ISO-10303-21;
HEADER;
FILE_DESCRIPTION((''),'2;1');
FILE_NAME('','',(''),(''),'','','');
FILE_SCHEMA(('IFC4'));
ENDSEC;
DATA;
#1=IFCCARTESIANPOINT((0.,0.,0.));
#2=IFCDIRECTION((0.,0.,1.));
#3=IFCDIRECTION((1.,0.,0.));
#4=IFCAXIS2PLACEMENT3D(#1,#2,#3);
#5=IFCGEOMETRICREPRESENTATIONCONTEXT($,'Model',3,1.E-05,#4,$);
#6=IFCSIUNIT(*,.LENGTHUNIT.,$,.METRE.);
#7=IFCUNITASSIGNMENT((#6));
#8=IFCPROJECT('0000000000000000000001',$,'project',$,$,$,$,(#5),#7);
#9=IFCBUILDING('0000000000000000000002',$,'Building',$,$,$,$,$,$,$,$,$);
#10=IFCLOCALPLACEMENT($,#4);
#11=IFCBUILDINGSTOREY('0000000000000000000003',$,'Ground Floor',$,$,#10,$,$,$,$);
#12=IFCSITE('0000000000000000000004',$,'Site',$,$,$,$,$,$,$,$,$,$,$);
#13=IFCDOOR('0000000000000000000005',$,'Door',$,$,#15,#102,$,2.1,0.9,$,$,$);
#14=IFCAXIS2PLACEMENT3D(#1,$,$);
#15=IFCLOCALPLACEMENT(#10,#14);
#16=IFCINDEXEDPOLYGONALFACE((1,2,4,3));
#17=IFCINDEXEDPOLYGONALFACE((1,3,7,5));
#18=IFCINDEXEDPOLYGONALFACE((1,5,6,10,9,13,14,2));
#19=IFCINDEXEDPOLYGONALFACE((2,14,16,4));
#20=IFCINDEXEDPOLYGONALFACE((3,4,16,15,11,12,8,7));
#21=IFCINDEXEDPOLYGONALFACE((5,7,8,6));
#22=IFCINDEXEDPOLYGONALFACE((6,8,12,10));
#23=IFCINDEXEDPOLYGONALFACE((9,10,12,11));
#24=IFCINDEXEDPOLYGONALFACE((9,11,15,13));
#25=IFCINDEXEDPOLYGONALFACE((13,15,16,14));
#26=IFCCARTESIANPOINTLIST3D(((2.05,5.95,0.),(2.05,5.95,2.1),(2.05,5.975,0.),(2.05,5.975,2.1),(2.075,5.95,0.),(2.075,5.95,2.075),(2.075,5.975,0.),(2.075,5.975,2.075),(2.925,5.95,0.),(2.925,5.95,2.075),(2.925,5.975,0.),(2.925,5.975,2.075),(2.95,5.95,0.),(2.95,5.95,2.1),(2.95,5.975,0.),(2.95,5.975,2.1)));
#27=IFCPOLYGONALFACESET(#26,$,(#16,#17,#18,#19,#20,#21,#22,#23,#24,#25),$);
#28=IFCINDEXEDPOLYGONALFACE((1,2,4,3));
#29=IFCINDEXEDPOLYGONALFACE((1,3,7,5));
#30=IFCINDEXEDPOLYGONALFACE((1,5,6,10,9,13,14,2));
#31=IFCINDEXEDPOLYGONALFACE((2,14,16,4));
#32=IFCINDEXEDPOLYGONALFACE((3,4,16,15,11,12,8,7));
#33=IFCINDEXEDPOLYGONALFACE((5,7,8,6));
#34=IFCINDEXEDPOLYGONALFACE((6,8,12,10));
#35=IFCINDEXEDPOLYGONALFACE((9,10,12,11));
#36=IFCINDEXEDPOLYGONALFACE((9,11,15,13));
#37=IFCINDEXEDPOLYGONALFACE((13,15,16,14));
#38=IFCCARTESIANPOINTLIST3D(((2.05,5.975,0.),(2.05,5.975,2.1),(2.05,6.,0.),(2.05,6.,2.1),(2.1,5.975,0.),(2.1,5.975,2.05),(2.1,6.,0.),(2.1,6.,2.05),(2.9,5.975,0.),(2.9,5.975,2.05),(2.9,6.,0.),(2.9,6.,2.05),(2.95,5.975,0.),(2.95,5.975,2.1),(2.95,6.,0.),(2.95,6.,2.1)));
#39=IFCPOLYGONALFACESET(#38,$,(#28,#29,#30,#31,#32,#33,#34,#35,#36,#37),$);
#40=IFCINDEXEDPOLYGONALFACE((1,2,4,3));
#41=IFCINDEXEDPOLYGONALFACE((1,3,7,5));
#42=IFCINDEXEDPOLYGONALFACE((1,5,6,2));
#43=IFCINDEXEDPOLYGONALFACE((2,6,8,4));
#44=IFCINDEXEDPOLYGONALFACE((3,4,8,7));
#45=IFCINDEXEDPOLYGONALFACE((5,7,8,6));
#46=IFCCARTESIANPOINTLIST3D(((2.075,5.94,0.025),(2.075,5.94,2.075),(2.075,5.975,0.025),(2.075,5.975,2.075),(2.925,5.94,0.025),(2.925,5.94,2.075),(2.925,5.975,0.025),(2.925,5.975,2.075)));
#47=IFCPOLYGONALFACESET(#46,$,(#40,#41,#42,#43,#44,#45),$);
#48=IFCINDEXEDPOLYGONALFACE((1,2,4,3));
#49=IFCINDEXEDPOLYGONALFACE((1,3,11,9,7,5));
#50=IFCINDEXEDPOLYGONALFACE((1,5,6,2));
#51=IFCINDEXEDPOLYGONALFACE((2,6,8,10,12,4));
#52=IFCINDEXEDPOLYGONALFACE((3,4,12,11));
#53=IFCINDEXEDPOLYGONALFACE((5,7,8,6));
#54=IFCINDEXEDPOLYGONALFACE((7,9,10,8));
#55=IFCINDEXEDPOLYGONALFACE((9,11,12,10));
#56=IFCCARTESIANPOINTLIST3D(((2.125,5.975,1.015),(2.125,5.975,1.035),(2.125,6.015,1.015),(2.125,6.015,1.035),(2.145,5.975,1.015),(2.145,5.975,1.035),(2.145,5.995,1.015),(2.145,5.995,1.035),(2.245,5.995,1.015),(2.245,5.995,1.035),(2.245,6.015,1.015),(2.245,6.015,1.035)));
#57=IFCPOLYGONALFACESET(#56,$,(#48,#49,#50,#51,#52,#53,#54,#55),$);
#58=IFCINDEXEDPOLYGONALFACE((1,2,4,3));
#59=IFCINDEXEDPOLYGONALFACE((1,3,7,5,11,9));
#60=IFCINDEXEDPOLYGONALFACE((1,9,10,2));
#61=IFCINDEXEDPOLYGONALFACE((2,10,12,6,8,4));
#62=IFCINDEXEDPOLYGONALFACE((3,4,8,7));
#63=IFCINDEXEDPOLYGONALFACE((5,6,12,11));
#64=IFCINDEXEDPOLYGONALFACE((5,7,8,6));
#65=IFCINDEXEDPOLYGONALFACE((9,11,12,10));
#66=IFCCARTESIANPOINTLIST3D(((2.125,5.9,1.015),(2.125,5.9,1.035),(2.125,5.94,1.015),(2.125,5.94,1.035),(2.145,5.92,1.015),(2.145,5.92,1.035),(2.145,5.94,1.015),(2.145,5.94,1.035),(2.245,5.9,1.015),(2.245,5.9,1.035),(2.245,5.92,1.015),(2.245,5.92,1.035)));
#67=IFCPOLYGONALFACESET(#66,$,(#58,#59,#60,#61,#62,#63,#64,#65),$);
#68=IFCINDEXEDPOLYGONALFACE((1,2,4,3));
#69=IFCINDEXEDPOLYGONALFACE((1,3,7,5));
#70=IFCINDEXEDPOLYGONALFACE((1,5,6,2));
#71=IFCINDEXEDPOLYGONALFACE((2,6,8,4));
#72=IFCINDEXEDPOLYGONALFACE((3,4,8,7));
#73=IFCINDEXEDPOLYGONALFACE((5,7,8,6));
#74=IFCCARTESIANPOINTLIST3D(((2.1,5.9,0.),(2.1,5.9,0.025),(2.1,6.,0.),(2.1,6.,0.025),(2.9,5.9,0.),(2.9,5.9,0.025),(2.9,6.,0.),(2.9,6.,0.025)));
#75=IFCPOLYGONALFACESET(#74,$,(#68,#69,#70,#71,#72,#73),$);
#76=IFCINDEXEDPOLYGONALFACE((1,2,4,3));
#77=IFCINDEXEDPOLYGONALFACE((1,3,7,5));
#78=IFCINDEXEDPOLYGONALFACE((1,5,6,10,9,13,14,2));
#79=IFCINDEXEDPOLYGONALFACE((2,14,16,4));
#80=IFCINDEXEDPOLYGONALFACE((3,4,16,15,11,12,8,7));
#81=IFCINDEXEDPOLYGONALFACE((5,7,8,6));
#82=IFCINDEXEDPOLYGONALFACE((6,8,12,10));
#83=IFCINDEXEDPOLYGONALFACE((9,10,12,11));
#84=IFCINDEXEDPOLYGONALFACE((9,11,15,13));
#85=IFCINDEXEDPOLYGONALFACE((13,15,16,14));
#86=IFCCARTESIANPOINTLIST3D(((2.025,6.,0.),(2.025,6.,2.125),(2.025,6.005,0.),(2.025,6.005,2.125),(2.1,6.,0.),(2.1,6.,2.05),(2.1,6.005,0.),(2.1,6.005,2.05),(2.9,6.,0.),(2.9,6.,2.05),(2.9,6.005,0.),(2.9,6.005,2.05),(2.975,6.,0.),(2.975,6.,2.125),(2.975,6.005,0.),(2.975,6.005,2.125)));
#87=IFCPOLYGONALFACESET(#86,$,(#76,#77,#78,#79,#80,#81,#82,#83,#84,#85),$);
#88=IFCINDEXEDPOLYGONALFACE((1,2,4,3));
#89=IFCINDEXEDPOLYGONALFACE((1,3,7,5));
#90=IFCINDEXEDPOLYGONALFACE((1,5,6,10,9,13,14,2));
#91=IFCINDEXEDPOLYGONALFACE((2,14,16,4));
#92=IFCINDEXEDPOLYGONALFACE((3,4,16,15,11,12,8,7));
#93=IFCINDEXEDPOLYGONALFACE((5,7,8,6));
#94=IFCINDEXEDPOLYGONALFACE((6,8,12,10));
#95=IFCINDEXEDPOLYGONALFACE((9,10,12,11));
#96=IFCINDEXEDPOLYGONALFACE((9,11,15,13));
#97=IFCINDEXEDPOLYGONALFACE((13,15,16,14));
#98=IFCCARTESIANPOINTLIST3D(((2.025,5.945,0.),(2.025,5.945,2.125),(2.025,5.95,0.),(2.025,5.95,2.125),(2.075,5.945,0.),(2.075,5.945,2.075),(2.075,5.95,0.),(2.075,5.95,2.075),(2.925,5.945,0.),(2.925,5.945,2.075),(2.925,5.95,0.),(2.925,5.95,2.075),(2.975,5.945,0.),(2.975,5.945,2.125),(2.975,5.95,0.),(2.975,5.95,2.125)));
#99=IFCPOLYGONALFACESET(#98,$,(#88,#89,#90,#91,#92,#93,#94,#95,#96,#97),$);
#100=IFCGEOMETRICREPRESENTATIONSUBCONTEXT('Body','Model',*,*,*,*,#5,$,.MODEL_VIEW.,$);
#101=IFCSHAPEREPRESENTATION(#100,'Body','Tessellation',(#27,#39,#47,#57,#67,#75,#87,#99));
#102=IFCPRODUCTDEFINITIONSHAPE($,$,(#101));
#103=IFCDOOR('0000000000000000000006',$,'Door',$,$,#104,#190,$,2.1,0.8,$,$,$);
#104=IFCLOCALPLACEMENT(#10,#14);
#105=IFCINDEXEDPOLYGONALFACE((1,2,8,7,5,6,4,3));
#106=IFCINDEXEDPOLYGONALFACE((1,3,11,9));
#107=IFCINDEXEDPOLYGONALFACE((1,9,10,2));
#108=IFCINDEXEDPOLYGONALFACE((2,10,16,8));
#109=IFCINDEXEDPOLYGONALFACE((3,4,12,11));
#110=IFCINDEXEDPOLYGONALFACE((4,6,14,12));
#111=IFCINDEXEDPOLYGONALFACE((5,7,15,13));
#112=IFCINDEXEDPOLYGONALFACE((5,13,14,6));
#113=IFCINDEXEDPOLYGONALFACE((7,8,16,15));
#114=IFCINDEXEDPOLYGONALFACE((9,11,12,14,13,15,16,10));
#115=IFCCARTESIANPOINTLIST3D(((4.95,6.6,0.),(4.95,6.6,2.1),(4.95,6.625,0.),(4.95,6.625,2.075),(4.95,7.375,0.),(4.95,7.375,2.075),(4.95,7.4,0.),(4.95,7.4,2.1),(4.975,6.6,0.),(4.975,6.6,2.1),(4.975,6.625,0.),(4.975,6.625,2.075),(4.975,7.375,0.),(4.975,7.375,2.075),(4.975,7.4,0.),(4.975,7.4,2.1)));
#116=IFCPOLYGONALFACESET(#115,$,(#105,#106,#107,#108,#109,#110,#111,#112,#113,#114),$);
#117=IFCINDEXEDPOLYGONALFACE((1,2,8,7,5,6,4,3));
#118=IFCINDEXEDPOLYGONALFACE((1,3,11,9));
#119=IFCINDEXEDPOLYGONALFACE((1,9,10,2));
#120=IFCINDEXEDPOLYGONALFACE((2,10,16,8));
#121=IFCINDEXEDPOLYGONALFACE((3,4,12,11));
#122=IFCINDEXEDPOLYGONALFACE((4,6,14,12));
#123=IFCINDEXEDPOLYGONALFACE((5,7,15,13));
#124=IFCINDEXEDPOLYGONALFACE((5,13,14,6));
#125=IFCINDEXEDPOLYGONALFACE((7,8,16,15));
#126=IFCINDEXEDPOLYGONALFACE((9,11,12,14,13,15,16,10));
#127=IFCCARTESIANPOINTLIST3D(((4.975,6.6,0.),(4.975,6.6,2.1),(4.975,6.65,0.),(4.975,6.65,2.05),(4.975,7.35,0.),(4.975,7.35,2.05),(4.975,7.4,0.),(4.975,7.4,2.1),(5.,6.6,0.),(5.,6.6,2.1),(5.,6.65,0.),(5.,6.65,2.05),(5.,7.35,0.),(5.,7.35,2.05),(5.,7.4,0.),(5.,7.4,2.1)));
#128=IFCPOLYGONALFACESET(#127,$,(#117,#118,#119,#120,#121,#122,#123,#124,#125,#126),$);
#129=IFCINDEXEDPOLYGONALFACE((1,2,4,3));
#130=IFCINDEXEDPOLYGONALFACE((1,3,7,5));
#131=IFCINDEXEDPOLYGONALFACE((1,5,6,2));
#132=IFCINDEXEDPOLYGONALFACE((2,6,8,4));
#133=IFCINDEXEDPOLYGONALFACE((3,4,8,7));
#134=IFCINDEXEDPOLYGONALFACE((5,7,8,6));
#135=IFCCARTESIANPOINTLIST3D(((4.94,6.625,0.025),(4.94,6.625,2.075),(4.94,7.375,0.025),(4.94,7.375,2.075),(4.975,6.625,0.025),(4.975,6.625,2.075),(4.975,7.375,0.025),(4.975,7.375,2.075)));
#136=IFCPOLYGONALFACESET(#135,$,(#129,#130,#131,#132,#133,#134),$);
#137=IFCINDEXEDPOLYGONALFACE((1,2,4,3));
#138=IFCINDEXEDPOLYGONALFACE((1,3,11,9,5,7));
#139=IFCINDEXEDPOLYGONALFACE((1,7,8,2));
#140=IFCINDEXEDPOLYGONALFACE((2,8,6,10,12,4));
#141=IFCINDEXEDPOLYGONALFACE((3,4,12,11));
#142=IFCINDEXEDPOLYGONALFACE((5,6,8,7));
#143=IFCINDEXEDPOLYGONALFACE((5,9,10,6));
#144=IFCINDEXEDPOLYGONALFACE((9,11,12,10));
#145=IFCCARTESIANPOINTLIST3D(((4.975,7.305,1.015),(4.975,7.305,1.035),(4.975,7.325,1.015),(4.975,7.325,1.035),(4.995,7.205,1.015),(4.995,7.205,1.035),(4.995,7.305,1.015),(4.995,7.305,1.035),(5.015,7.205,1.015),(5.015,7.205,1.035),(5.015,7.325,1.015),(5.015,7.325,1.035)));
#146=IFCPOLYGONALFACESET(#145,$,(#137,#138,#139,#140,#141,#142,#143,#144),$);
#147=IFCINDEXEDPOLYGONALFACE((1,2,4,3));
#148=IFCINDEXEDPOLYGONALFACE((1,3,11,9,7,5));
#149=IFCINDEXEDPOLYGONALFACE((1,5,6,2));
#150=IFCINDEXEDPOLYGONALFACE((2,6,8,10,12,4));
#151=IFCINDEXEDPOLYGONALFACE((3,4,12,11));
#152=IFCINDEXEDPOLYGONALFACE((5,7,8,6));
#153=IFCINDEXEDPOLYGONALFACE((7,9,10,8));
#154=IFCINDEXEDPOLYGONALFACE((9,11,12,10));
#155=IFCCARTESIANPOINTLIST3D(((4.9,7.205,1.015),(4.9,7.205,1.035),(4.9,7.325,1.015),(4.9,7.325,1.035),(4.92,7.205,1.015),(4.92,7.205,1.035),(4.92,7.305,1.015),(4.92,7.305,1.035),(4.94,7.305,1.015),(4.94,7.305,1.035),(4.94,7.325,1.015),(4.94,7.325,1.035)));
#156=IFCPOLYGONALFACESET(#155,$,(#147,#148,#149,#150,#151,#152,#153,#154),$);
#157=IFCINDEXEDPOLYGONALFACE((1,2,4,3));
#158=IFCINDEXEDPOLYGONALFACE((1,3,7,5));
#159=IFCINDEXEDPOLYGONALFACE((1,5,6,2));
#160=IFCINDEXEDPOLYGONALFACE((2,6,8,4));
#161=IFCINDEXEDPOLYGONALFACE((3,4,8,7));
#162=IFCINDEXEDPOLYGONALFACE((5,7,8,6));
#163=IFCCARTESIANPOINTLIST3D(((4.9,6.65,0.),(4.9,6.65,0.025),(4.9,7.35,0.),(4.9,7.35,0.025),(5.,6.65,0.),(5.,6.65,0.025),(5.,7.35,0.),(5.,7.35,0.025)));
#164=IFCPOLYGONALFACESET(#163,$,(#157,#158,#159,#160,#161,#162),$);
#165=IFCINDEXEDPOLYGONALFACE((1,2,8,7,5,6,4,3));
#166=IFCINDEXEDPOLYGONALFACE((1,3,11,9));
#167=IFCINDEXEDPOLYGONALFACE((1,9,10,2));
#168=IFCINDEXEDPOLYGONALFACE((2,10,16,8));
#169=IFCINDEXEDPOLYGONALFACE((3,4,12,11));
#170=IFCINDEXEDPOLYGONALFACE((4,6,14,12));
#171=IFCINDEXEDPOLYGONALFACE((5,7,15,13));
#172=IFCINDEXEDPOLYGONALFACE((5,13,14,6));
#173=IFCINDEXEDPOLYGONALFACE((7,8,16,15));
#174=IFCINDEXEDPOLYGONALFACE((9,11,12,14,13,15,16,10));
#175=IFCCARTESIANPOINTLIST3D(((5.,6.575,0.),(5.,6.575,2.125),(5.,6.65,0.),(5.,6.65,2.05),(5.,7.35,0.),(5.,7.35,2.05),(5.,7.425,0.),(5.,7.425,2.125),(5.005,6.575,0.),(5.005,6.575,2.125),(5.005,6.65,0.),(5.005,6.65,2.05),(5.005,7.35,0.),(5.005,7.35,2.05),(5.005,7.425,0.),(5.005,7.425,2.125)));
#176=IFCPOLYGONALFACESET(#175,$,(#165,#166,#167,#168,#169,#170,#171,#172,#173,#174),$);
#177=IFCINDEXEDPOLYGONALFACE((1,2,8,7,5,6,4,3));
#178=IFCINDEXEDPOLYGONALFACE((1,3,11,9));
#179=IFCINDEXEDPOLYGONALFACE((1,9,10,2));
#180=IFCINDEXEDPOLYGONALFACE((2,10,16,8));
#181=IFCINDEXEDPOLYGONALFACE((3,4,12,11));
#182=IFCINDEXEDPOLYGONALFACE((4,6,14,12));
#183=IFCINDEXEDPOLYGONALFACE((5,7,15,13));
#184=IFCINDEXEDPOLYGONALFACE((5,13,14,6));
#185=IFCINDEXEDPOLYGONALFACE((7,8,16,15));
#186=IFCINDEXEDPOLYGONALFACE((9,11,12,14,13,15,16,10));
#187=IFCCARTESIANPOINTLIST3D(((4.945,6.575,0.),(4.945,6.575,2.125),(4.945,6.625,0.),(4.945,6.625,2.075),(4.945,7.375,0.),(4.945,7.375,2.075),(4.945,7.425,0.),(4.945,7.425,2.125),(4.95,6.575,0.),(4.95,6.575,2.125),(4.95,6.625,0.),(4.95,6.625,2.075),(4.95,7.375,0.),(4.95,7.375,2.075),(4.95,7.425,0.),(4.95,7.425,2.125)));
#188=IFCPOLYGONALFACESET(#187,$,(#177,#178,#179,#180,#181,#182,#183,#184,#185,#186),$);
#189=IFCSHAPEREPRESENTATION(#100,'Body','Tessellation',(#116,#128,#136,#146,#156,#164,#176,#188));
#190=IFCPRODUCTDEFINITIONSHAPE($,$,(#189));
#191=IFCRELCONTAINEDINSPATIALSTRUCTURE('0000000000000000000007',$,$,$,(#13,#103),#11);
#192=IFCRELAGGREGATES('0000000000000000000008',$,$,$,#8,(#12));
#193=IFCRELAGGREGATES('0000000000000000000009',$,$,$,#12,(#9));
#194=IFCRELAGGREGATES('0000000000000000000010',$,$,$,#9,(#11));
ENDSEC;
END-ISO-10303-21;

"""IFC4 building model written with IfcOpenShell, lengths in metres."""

from ifc_helpers import new_model, si_unit, frame, origin_with_axes, place, context, subcontext, project, spatial, line, indexed_curve, outline, extrude, element, save


model = new_model("IFC4")

# Units and contexts
model_context = context("Model", 3, precision=1e-05, world=origin_with_axes())
body_context = subcontext(model_context, "Body", "Model", "MODEL_VIEW")
ifc_project = project(units=[si_unit("LENGTHUNIT", "METRE")], contexts=[model_context])

# Site, building, storey
site = spatial("IfcSite", under=ifc_project, Name="Site")
building = spatial("IfcBuilding", under=site, Name="Building")
storey_placement = place(None, origin_with_axes())
storey = spatial("IfcBuildingStorey", under=building, at=storey_placement, Name="Ground Floor")

# Doors
door_1_placement = place(storey_placement, frame((2.95, 6.0, 0.0), z_axis=(0.0, 0.0, 1.0), x_axis=(-1.0, 0.0, 0.0)))
element("IfcDoor", 1, at=door_1_placement, inside=storey, Name="Door", OverallHeight=2.1, OverallWidth=0.9, context=body_context, shape_type="SweptSolid", body=[
    extrude(outline(indexed_curve([(0.0, 0.0), (0.0, 2.1), (0.9, 2.1), (0.9, 0.0), (0.875, 0.0), (0.875, 2.075), (0.025, 2.075), (0.025, 0.0)], segments=[line(1, 2, 3, 4, 5, 6, 7, 8, 1)])), frame((0.0, 0.025, 0.0), z_axis=(0.0, -1.0, 0.0), x_axis=(1.0, 0.0, 0.0)), (0.0, 0.0, -1.0), 0.025),
    extrude(outline(indexed_curve([(0.0, 0.0), (0.0, 2.1), (0.9, 2.1), (0.9, 0.0), (0.85, 0.0), (0.85, 2.05), (0.05, 2.05), (0.05, 0.0)], segments=[line(1, 2, 3, 4, 5, 6, 7, 8, 1)])), frame((0.0, 0.0, 0.0), z_axis=(0.0, -1.0, 0.0), x_axis=(1.0, 0.0, 0.0)), (0.0, 0.0, -1.0), 0.025),
    extrude(outline(indexed_curve([(0.0, 0.0), (0.85, 0.0), (0.85, 0.035), (0.0, 0.035)], segments=[line(1, 2, 3, 4, 1)])), frame((0.025, 0.025, 0.025), z_axis=(0.0, 0.0, 1.0), x_axis=(1.0, 0.0, 0.0)), (0.0, 0.0, 1.0), 2.05),
    extrude(outline(indexed_curve([(0.0, 0.0), (0.0, -0.04), (-0.12, -0.04), (-0.12, -0.02), (-0.02, -0.02), (-0.02, 0.0)], segments=[line(1, 2, 3, 4, 5, 6, 1)])), frame((0.825, 0.025, 1.015), z_axis=(0.0, 0.0, 1.0), x_axis=(1.0, 0.0, 0.0)), (0.0, 0.0, 1.0), 0.02),
    extrude(outline(indexed_curve([(0.0, 0.0), (0.0, 0.04), (-0.12, 0.04), (-0.12, 0.02), (-0.02, 0.02), (-0.02, 0.0)], segments=[line(1, 2, 3, 4, 5, 6, 1)])), frame((0.825, 0.06, 1.015), z_axis=(0.0, 0.0, 1.0), x_axis=(1.0, 0.0, 0.0)), (0.0, 0.0, 1.0), 0.02),
    extrude(outline(indexed_curve([(0.0, 0.0), (0.8, 0.0), (0.8, 0.1), (0.0, 0.1)], segments=[line(1, 2, 3, 4, 1)])), frame((0.05, 0.0, 0.0), z_axis=(0.0, 0.0, 1.0), x_axis=(1.0, 0.0, 0.0)), (0.0, 0.0, 1.0), 0.025),
    extrude(outline(indexed_curve([(0.0, 0.0), (0.0, 2.125), (0.95, 2.125), (0.95, 0.0), (0.875, 0.0), (0.875, 2.05), (0.075, 2.05), (0.075, 0.0)], segments=[line(1, 2, 3, 4, 5, 6, 7, 8, 1)])), frame((-0.025, -0.005, 0.0), z_axis=(0.0, -1.0, 0.0), x_axis=(1.0, 0.0, 0.0)), (0.0, 0.0, -1.0), 0.005),
    extrude(outline(indexed_curve([(0.0, 0.0), (0.0, 2.125), (0.95, 2.125), (0.95, 0.0), (0.9, 0.0), (0.9, 2.075), (0.05, 2.075), (0.05, 0.0)], segments=[line(1, 2, 3, 4, 5, 6, 7, 8, 1)])), frame((-0.025, 0.05, 0.0), z_axis=(0.0, -1.0, 0.0), x_axis=(1.0, 0.0, 0.0)), (0.0, 0.0, -1.0), 0.005),
])
door_2_placement = place(storey_placement, frame((5.0, 6.6, 0.0), z_axis=(0.0, 0.0, 1.0), x_axis=(0.0, 1.0, 0.0)))
element("IfcDoor", 2, at=door_2_placement, inside=storey, Name="Door", OverallHeight=2.1, OverallWidth=0.8, context=body_context, shape_type="SweptSolid", body=[
    extrude(outline(indexed_curve([(0.0, 0.0), (0.0, 2.1), (0.8, 2.1), (0.8, 0.0), (0.775, 0.0), (0.775, 2.075), (0.025, 2.075), (0.025, 0.0)], segments=[line(1, 2, 3, 4, 5, 6, 7, 8, 1)])), frame((0.0, 0.025, 0.0), z_axis=(0.0, -1.0, 0.0), x_axis=(1.0, 0.0, 0.0)), (0.0, 0.0, -1.0), 0.025),
    extrude(outline(indexed_curve([(0.0, 0.0), (0.0, 2.1), (0.8, 2.1), (0.8, 0.0), (0.75, 0.0), (0.75, 2.05), (0.05, 2.05), (0.05, 0.0)], segments=[line(1, 2, 3, 4, 5, 6, 7, 8, 1)])), frame((0.0, 0.0, 0.0), z_axis=(0.0, -1.0, 0.0), x_axis=(1.0, 0.0, 0.0)), (0.0, 0.0, -1.0), 0.025),
    extrude(outline(indexed_curve([(0.0, 0.0), (0.75, 0.0), (0.75, 0.035), (0.0, 0.035)], segments=[line(1, 2, 3, 4, 1)])), frame((0.025, 0.025, 0.025), z_axis=(0.0, 0.0, 1.0), x_axis=(1.0, 0.0, 0.0)), (0.0, 0.0, 1.0), 2.05),
    extrude(outline(indexed_curve([(0.0, 0.0), (0.0, -0.04), (-0.12, -0.04), (-0.12, -0.02), (-0.02, -0.02), (-0.02, 0.0)], segments=[line(1, 2, 3, 4, 5, 6, 1)])), frame((0.725, 0.025, 1.015), z_axis=(0.0, 0.0, 1.0), x_axis=(1.0, 0.0, 0.0)), (0.0, 0.0, 1.0), 0.02),
    extrude(outline(indexed_curve([(0.0, 0.0), (0.0, 0.04), (-0.12, 0.04), (-0.12, 0.02), (-0.02, 0.02), (-0.02, 0.0)], segments=[line(1, 2, 3, 4, 5, 6, 1)])), frame((0.725, 0.06, 1.015), z_axis=(0.0, 0.0, 1.0), x_axis=(1.0, 0.0, 0.0)), (0.0, 0.0, 1.0), 0.02),
    extrude(outline(indexed_curve([(0.0, 0.0), (0.7, 0.0), (0.7, 0.1), (0.0, 0.1)], segments=[line(1, 2, 3, 4, 1)])), frame((0.05, 0.0, 0.0), z_axis=(0.0, 0.0, 1.0), x_axis=(1.0, 0.0, 0.0)), (0.0, 0.0, 1.0), 0.025),
    extrude(outline(indexed_curve([(0.0, 0.0), (0.0, 2.125), (0.85, 2.125), (0.85, 0.0), (0.775, 0.0), (0.775, 2.05), (0.075, 2.05), (0.075, 0.0)], segments=[line(1, 2, 3, 4, 5, 6, 7, 8, 1)])), frame((-0.025, -0.005, 0.0), z_axis=(0.0, -1.0, 0.0), x_axis=(1.0, 0.0, 0.0)), (0.0, 0.0, -1.0), 0.005),
    extrude(outline(indexed_curve([(0.0, 0.0), (0.0, 2.125), (0.85, 2.125), (0.85, 0.0), (0.8, 0.0), (0.8, 2.075), (0.05, 2.075), (0.05, 0.0)], segments=[line(1, 2, 3, 4, 5, 6, 7, 8, 1)])), frame((-0.025, 0.05, 0.0), z_axis=(0.0, -1.0, 0.0), x_axis=(1.0, 0.0, 0.0)), (0.0, 0.0, -1.0), 0.005),
])

save(model, "model.ifc")
